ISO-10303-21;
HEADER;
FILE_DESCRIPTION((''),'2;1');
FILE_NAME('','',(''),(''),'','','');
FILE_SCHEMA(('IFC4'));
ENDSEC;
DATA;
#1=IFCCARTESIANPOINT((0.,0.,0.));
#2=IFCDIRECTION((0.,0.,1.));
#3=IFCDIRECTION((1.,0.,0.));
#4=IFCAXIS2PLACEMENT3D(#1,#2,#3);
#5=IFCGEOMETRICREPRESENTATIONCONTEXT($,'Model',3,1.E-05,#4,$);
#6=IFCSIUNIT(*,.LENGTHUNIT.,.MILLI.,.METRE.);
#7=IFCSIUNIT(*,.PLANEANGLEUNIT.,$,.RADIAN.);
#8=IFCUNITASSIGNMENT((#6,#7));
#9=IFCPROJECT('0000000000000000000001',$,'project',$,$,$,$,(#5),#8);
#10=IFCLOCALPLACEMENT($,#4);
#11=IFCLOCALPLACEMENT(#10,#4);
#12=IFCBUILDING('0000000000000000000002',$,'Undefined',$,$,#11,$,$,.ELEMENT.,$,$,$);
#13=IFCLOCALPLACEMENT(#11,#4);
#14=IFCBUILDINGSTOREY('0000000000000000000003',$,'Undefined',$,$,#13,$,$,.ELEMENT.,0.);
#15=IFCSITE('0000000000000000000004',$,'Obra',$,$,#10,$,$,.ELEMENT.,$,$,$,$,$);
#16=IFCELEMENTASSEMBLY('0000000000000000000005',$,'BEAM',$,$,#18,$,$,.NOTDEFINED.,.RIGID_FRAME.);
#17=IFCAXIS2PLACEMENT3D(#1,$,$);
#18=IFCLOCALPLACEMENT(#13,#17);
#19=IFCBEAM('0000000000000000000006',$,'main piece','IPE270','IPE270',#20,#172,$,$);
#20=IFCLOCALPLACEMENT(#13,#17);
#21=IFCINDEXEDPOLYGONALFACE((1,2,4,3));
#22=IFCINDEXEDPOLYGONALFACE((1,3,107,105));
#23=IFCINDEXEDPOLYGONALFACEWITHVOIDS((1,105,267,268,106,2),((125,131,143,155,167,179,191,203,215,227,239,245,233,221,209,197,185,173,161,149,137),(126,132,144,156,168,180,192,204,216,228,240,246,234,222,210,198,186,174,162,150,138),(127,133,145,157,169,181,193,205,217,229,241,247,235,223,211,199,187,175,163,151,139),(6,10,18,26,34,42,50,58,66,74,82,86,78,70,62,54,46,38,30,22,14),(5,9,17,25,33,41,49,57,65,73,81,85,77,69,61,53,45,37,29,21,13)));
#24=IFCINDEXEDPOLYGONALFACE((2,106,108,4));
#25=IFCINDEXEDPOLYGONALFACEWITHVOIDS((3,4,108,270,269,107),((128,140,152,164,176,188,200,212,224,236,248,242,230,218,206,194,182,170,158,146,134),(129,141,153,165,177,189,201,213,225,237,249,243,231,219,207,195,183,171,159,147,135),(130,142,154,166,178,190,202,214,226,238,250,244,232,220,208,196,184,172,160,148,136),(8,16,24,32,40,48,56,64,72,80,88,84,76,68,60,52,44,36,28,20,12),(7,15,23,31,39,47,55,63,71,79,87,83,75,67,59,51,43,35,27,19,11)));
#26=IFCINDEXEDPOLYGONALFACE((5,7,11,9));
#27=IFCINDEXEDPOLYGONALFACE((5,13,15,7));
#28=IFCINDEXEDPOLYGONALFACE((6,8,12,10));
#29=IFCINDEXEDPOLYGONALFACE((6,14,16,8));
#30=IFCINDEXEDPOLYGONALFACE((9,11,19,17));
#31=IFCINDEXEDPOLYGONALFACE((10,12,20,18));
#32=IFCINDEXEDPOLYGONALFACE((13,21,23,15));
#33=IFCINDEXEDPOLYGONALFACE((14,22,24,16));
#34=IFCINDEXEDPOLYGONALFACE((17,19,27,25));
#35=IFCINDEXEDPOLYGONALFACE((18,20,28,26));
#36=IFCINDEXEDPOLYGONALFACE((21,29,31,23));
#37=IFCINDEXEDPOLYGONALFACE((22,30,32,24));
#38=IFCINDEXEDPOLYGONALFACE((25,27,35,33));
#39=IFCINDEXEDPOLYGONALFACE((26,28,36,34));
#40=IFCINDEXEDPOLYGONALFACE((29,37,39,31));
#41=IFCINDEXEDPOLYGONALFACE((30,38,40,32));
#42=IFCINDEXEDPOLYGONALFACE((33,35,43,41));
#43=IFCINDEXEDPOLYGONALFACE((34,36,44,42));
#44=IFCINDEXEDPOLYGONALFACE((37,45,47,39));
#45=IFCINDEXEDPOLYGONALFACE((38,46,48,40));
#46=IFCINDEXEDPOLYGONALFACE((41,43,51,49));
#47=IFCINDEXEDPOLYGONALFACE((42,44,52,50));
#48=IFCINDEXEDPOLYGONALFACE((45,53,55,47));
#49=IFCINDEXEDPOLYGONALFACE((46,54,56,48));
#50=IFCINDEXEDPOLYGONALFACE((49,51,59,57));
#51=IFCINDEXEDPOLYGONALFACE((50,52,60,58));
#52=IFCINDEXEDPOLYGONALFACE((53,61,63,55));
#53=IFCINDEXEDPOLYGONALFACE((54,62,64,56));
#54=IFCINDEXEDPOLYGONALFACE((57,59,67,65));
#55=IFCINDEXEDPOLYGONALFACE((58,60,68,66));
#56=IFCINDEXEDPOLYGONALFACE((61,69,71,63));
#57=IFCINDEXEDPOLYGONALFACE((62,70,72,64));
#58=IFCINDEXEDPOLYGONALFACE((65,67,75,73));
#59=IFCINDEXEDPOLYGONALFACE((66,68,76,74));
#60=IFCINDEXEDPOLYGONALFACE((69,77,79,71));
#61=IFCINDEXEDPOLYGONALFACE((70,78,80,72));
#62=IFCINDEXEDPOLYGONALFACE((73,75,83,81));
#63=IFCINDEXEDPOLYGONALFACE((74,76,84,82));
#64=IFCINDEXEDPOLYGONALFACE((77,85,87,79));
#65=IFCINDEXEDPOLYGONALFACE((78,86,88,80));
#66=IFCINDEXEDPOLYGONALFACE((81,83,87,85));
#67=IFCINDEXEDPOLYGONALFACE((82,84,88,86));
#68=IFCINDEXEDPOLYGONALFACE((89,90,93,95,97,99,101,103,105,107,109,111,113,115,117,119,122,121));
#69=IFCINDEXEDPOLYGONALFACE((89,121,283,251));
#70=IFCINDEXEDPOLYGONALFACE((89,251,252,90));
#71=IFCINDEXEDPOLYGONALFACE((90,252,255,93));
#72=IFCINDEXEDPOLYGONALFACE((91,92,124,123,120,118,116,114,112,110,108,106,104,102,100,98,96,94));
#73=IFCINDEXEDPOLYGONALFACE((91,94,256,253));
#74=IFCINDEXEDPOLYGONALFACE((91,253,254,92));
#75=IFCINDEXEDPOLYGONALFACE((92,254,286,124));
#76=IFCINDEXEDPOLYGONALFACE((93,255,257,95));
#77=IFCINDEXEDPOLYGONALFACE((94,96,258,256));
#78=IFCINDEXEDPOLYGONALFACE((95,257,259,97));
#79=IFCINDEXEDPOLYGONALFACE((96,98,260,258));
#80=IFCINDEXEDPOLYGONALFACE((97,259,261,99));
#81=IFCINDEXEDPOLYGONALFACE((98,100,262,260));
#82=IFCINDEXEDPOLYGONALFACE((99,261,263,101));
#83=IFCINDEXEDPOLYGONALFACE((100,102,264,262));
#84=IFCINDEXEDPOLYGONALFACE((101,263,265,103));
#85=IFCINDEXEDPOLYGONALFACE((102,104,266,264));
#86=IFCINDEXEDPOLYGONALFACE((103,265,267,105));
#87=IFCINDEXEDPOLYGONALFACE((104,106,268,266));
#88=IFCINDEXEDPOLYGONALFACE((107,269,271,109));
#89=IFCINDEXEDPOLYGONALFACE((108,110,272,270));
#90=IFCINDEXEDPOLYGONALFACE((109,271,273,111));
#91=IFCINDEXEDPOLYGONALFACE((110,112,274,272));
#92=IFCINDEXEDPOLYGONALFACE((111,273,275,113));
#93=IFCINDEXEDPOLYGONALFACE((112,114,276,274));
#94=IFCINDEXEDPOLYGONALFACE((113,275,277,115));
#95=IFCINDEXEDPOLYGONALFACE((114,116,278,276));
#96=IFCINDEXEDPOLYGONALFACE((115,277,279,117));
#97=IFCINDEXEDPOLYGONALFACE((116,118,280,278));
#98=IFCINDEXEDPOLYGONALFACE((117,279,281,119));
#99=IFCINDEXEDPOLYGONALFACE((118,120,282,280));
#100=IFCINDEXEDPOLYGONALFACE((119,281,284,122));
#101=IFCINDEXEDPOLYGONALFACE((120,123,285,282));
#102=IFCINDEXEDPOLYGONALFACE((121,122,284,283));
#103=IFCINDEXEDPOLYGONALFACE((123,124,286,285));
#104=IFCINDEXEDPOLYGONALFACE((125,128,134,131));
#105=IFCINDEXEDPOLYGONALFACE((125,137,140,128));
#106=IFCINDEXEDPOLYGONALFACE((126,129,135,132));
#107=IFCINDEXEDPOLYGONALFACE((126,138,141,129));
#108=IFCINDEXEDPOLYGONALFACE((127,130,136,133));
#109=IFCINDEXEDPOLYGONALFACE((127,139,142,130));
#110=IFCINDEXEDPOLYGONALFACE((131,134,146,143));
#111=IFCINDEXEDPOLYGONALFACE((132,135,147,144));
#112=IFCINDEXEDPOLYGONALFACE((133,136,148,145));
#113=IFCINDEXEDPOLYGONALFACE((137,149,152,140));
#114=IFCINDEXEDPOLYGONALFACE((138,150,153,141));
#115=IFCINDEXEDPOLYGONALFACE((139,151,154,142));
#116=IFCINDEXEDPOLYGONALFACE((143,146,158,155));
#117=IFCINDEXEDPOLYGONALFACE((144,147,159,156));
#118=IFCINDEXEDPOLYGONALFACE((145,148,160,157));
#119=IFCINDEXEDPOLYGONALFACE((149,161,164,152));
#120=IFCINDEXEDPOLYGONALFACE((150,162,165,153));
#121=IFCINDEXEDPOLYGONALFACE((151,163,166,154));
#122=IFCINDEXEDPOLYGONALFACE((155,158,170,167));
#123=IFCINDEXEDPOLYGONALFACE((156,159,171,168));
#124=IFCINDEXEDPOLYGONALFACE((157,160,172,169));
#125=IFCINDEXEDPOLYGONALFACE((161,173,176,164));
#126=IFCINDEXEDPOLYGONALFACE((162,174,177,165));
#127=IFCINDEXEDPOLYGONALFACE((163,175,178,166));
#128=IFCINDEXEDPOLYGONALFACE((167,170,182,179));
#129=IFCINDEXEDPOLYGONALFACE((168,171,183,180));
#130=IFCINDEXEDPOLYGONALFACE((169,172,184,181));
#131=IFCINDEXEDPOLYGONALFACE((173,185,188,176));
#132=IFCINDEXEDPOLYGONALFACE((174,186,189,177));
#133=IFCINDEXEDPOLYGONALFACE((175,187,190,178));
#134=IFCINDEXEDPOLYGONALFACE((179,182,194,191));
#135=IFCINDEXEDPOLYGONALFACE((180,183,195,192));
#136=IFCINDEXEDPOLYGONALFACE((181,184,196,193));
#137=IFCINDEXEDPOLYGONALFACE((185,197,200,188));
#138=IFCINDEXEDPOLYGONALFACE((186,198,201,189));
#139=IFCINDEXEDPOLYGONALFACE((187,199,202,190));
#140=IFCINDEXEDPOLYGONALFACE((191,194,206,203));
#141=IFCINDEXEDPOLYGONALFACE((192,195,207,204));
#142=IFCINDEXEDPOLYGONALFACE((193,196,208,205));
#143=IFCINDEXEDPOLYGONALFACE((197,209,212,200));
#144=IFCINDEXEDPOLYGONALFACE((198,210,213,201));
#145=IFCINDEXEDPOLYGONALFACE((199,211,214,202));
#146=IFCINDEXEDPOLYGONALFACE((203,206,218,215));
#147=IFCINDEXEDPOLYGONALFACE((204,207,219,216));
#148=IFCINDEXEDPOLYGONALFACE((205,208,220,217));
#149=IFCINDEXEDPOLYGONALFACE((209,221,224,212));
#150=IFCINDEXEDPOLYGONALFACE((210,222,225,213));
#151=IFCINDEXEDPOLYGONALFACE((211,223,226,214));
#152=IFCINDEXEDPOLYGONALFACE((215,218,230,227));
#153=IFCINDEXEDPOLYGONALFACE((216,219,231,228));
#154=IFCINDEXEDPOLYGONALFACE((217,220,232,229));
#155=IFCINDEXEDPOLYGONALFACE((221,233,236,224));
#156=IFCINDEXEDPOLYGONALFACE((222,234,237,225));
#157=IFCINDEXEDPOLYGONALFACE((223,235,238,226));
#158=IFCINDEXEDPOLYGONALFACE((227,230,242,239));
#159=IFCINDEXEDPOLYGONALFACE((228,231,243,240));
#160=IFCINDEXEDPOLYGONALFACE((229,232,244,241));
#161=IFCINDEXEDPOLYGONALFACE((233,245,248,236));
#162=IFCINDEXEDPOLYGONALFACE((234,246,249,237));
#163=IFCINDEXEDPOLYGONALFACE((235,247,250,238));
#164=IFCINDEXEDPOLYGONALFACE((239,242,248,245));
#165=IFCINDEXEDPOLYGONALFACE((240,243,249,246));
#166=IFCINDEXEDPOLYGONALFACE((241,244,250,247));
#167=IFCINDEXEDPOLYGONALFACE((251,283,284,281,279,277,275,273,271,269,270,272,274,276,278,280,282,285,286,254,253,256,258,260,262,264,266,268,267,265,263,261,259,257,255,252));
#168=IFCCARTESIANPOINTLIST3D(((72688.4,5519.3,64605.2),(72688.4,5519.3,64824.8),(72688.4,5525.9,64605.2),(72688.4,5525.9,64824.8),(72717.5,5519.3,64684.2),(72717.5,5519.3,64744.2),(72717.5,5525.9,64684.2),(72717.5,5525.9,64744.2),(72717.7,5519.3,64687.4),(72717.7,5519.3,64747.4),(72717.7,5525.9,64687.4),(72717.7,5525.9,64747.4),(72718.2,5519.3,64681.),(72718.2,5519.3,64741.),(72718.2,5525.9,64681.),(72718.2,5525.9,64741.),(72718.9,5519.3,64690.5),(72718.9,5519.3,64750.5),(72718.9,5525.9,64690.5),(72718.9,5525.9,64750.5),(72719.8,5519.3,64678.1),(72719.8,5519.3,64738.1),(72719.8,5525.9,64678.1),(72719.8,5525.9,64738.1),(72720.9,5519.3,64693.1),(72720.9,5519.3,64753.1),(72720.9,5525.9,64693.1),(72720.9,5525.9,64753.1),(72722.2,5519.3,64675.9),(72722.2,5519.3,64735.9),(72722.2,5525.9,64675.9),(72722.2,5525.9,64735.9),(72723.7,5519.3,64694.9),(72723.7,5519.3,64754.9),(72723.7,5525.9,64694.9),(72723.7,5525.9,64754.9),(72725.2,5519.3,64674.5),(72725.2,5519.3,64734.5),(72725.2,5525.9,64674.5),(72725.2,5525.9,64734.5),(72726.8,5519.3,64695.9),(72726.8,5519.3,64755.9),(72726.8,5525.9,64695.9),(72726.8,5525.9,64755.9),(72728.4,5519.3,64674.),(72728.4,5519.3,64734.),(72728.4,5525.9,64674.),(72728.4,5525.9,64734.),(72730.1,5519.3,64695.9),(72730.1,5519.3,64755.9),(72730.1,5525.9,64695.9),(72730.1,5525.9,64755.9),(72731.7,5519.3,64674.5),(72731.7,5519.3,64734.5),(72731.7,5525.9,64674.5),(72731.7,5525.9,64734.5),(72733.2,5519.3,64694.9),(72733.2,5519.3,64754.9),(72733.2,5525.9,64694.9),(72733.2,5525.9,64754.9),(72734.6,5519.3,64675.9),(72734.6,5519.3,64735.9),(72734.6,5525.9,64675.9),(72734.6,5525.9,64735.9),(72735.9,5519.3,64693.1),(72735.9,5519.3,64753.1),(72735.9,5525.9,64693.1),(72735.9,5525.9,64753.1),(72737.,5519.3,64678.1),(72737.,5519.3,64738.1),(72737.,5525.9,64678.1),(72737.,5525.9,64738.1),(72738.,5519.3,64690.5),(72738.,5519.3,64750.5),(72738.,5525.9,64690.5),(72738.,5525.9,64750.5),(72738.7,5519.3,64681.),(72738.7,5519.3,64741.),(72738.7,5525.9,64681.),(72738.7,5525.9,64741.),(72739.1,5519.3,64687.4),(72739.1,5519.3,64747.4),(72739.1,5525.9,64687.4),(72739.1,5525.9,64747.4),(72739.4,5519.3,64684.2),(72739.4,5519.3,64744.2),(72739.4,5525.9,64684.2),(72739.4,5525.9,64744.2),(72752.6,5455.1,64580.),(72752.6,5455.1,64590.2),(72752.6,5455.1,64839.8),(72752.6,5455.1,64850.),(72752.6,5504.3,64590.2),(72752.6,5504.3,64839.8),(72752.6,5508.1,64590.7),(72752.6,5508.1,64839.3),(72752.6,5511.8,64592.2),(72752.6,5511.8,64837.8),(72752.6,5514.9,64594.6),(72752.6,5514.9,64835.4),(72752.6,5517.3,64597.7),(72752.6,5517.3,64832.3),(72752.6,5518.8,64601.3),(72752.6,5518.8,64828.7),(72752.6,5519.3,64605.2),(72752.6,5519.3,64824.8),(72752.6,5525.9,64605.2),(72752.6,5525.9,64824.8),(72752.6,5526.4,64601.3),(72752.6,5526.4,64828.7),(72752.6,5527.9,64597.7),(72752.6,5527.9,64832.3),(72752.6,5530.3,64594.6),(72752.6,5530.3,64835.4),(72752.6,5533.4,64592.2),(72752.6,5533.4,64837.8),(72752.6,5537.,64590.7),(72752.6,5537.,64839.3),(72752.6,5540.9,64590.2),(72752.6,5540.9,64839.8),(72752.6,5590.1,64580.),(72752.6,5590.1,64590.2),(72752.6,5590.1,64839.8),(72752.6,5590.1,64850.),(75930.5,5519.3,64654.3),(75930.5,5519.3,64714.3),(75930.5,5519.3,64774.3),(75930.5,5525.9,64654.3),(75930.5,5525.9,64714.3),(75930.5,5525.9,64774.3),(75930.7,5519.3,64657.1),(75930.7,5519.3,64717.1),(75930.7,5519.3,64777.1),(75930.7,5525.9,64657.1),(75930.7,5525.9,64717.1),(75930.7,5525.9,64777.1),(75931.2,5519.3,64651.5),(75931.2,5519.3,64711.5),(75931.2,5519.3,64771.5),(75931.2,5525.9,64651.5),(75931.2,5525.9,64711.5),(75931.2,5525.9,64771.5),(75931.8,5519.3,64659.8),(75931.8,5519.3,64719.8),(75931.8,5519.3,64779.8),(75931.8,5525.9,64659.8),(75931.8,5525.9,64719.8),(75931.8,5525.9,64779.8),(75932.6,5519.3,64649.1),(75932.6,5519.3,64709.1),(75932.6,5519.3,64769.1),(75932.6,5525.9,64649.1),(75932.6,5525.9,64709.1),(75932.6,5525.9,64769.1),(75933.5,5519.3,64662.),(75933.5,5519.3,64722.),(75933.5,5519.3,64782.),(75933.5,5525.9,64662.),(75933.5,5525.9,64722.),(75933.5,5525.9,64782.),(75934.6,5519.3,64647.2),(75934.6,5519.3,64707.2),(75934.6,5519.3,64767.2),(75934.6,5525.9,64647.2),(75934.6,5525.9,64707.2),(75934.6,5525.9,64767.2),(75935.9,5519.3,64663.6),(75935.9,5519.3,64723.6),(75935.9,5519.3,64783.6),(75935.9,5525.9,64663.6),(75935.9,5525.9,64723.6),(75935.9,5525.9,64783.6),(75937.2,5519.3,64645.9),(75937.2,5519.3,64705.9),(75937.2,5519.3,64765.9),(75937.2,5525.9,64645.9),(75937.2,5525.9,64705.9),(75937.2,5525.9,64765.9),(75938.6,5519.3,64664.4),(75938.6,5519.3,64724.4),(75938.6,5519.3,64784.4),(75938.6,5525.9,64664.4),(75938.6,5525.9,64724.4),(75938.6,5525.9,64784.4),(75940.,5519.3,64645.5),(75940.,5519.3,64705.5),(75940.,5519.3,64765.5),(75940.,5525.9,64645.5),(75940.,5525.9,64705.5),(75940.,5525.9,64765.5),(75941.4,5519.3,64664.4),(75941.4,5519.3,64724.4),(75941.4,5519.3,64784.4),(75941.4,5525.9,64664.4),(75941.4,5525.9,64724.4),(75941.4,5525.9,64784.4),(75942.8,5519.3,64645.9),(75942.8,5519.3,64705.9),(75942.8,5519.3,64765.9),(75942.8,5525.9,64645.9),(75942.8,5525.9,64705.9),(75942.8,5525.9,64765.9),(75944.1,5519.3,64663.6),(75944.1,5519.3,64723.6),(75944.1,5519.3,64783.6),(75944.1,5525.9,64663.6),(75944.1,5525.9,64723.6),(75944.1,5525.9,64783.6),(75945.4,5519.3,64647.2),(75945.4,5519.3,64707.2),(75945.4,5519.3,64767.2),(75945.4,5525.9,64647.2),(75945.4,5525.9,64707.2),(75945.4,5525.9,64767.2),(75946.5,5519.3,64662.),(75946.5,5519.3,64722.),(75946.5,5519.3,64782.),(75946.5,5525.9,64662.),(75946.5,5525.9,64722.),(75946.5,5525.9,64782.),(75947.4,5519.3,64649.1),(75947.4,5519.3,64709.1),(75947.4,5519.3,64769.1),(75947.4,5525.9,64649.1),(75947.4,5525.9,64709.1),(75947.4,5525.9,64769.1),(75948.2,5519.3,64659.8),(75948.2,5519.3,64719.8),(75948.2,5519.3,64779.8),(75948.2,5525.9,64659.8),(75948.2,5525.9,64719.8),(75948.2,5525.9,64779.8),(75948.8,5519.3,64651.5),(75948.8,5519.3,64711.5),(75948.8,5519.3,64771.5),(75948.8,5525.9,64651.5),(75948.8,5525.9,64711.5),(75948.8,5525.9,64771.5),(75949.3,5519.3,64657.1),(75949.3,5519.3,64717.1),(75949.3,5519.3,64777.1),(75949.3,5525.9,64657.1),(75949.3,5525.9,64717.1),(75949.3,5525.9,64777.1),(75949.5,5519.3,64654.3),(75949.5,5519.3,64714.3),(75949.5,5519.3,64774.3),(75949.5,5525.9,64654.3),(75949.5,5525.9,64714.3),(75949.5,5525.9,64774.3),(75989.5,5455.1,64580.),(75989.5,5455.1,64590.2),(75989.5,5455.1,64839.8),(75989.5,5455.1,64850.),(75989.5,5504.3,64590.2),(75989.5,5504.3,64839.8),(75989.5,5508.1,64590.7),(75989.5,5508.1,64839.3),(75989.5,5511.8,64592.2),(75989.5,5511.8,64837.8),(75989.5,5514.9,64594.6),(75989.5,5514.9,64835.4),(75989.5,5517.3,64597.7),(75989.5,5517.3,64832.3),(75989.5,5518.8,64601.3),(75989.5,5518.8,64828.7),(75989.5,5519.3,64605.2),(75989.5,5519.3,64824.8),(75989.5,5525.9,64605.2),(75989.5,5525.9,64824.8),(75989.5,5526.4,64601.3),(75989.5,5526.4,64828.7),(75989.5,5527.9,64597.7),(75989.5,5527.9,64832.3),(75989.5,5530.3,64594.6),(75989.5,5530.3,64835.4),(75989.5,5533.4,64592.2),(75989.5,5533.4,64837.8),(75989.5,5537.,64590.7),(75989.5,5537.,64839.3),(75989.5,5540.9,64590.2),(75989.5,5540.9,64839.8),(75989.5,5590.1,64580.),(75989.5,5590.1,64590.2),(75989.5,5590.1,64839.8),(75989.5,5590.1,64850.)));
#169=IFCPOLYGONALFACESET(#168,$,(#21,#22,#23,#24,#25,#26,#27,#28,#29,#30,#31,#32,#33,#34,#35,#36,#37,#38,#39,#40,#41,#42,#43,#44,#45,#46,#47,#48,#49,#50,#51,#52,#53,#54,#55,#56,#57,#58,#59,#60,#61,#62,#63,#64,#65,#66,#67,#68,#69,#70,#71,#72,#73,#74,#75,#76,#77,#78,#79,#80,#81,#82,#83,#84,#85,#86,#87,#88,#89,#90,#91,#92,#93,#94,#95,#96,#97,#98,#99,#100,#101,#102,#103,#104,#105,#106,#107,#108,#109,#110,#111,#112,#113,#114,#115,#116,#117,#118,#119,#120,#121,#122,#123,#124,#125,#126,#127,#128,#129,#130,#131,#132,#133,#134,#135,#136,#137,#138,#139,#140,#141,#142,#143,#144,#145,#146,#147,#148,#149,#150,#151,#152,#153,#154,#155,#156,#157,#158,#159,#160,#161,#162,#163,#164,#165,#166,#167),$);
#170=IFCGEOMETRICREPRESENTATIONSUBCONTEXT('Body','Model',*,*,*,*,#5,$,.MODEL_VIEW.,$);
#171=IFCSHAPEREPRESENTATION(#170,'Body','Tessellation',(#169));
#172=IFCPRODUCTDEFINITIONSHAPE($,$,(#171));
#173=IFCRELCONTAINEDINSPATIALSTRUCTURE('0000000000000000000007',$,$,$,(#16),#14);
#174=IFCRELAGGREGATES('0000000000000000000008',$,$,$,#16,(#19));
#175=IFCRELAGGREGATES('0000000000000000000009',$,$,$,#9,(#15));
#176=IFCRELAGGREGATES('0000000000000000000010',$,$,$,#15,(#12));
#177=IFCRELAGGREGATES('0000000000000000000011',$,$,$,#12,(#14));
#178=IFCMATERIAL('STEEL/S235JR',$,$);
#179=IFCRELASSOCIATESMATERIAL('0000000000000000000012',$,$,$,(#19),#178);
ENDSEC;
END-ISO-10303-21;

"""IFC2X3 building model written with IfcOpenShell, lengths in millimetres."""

from ifc_helpers import new_model, si_unit, frame, origin_with_axes, origin_2d_with_axis, place, context, subcontext, project, spatial, rectangle, circle, i_section, extrude, clip, halfspace, source, transform, mapped, material, element, aggregate, save


model = new_model("IFC2X3")

# Units and contexts
model_context = context("Model", 3, precision=1e-05, world=origin_with_axes())
body_context = subcontext(model_context, "Body", "Model", "MODEL_VIEW")
ifc_project = project(units=[si_unit("LENGTHUNIT", "METRE", prefix="MILLI"), si_unit("PLANEANGLEUNIT", "RADIAN")], contexts=[model_context])

# Site, building, storey
site_placement = place(None, origin_with_axes())
site = spatial("IfcSite", under=ifc_project, at=site_placement, Name="Obra", CompositionType="ELEMENT")
building_placement = place(site_placement, origin_with_axes())
building = spatial("IfcBuilding", under=site, at=building_placement, Name="Undefined", CompositionType="ELEMENT")
storey_placement = place(building_placement, origin_with_axes())
storey = spatial("IfcBuildingStorey", under=building, at=storey_placement, Name="Undefined", CompositionType="ELEMENT", Elevation=0.0)

# Element assembly, beam, openings
ifc_material_1 = material(Name="STEEL/S235JR")
assembly_1_placement = place(storey_placement, origin_with_axes())
assembly_1 = element("IfcElementAssembly", 1, at=assembly_1_placement, inside=storey, Name="BEAM", AssemblyPlace="NOTDEFINED", PredefinedType="RIGID_FRAME")
beam_1_placement = place(assembly_1_placement, frame((72747.9, 5522.6, 64715.0), z_axis=(0.0, 0.0, 1.0), x_axis=(1.0, 0.0, 0.0)))
beam_1 = element("IfcBeam", 2, at=beam_1_placement, material=ifc_material_1, Name="main piece", Description="IPE270", ObjectType="IPE270", context=body_context, shape_type="Clipping", body=[
    clip(clip(extrude(i_section(OverallWidth=135.0, OverallDepth=270.0, WebThickness=6.6, FlangeThickness=10.2, FilletRadius=15.0, at=origin_2d_with_axis()), frame((3352.2, 0.0, 0.0), z_axis=(-1.0, 0.0, 0.0), x_axis=(0.0, -1.0, 0.0)), (0.0, 0.0, 1.0), 3411.7), halfspace(frame((3241.7, -60.0, -120.0), z_axis=(1.0, 0.000019, 0.0), x_axis=(0.0, 0.0, 1.0)), False)), halfspace(frame((-59.5, 0.0, -235.0), z_axis=(1.0, 0.0, 0.0), x_axis=(0.0, -1.0, 0.0)), True)),
])
opening_1_placement = place(assembly_1_placement, frame((72747.9, 5522.6, 64715.0), z_axis=(0.0, 0.0, 1.0), x_axis=(1.0, 0.0, 0.0)))
element("IfcOpeningElement", 3, at=opening_1_placement, cuts=beam_1, ObjectType="Recess", context=body_context, shape_type="SweptSolid", body=[
    extrude(rectangle(XDim=26.2, YDim=76.2, at=origin_2d_with_axis()), frame((-33.4, -68.5, -122.9), z_axis=(0.0, 1.0, 0.0), x_axis=(0.0, 0.0, -1.0)), (0.0, 0.0, 1.0), 137.0),
])
opening_2_placement = place(assembly_1_placement, frame((72747.9, 5522.6, 64715.0), z_axis=(0.0, 0.0, 1.0), x_axis=(1.0, 0.0, 0.0)))
element("IfcOpeningElement", 4, at=opening_2_placement, cuts=beam_1, ObjectType="Recess", context=body_context, shape_type="SweptSolid", body=[
    extrude(rectangle(XDim=26.2, YDim=76.2, at=origin_2d_with_axis()), frame((-33.4, -68.5, 122.9), z_axis=(0.0, 1.0, 0.0), x_axis=(0.0, 0.0, -1.0)), (0.0, 0.0, 1.0), 137.0),
])
shared_shape_1 = source(origin_with_axes(), body_context, "Body", "SweptSolid", [
    extrude(circle(Radius=11.0, at=origin_2d_with_axis()), frame((0.0, -3.4, 0.0), z_axis=(0.0, 1.0, 0.0), x_axis=(1.0, 0.0, 0.0)), (0.0, 0.0, 1.0), 6.8),
])
opening_3_placement = place(assembly_1_placement, frame((72688.4, 5522.6, 64850.0), z_axis=(1.0, 0.0, 0.0), x_axis=(0.0, 0.0, -1.0)))
element("IfcOpeningElement", 5, at=opening_3_placement, cuts=beam_1, ObjectType="Opening", context=body_context, shape_type="MappedRepresentation", body=[
    mapped(shared_shape_1, transform((105.0, 0.0, 40.0))),
    mapped(shared_shape_1, transform((165.0, 0.0, 40.0))),
])
shared_shape_2 = source(origin_with_axes(), body_context, "Body", "SweptSolid", [
    extrude(circle(Radius=9.5, at=origin_2d_with_axis()), frame((0.0, -3.4, 0.0), z_axis=(0.0, 1.0, 0.0), x_axis=(1.0, 0.0, 0.0)), (0.0, 0.0, 1.0), 6.8),
])
opening_4_placement = place(assembly_1_placement, frame((75990.0, 5522.6, 64835.0), z_axis=(-1.0, 0.0, 0.0), x_axis=(0.0, 0.0, -1.0)))
element("IfcOpeningElement", 6, at=opening_4_placement, cuts=beam_1, ObjectType="Opening", context=body_context, shape_type="MappedRepresentation", body=[
    mapped(shared_shape_2, transform((60.0, 0.0, 50.0))),
    mapped(shared_shape_2, transform((120.0, 0.0, 50.0))),
    mapped(shared_shape_2, transform((180.0, 0.0, 50.0))),
])

aggregate(assembly_1, [beam_1])

save(model, "model.ifc")
